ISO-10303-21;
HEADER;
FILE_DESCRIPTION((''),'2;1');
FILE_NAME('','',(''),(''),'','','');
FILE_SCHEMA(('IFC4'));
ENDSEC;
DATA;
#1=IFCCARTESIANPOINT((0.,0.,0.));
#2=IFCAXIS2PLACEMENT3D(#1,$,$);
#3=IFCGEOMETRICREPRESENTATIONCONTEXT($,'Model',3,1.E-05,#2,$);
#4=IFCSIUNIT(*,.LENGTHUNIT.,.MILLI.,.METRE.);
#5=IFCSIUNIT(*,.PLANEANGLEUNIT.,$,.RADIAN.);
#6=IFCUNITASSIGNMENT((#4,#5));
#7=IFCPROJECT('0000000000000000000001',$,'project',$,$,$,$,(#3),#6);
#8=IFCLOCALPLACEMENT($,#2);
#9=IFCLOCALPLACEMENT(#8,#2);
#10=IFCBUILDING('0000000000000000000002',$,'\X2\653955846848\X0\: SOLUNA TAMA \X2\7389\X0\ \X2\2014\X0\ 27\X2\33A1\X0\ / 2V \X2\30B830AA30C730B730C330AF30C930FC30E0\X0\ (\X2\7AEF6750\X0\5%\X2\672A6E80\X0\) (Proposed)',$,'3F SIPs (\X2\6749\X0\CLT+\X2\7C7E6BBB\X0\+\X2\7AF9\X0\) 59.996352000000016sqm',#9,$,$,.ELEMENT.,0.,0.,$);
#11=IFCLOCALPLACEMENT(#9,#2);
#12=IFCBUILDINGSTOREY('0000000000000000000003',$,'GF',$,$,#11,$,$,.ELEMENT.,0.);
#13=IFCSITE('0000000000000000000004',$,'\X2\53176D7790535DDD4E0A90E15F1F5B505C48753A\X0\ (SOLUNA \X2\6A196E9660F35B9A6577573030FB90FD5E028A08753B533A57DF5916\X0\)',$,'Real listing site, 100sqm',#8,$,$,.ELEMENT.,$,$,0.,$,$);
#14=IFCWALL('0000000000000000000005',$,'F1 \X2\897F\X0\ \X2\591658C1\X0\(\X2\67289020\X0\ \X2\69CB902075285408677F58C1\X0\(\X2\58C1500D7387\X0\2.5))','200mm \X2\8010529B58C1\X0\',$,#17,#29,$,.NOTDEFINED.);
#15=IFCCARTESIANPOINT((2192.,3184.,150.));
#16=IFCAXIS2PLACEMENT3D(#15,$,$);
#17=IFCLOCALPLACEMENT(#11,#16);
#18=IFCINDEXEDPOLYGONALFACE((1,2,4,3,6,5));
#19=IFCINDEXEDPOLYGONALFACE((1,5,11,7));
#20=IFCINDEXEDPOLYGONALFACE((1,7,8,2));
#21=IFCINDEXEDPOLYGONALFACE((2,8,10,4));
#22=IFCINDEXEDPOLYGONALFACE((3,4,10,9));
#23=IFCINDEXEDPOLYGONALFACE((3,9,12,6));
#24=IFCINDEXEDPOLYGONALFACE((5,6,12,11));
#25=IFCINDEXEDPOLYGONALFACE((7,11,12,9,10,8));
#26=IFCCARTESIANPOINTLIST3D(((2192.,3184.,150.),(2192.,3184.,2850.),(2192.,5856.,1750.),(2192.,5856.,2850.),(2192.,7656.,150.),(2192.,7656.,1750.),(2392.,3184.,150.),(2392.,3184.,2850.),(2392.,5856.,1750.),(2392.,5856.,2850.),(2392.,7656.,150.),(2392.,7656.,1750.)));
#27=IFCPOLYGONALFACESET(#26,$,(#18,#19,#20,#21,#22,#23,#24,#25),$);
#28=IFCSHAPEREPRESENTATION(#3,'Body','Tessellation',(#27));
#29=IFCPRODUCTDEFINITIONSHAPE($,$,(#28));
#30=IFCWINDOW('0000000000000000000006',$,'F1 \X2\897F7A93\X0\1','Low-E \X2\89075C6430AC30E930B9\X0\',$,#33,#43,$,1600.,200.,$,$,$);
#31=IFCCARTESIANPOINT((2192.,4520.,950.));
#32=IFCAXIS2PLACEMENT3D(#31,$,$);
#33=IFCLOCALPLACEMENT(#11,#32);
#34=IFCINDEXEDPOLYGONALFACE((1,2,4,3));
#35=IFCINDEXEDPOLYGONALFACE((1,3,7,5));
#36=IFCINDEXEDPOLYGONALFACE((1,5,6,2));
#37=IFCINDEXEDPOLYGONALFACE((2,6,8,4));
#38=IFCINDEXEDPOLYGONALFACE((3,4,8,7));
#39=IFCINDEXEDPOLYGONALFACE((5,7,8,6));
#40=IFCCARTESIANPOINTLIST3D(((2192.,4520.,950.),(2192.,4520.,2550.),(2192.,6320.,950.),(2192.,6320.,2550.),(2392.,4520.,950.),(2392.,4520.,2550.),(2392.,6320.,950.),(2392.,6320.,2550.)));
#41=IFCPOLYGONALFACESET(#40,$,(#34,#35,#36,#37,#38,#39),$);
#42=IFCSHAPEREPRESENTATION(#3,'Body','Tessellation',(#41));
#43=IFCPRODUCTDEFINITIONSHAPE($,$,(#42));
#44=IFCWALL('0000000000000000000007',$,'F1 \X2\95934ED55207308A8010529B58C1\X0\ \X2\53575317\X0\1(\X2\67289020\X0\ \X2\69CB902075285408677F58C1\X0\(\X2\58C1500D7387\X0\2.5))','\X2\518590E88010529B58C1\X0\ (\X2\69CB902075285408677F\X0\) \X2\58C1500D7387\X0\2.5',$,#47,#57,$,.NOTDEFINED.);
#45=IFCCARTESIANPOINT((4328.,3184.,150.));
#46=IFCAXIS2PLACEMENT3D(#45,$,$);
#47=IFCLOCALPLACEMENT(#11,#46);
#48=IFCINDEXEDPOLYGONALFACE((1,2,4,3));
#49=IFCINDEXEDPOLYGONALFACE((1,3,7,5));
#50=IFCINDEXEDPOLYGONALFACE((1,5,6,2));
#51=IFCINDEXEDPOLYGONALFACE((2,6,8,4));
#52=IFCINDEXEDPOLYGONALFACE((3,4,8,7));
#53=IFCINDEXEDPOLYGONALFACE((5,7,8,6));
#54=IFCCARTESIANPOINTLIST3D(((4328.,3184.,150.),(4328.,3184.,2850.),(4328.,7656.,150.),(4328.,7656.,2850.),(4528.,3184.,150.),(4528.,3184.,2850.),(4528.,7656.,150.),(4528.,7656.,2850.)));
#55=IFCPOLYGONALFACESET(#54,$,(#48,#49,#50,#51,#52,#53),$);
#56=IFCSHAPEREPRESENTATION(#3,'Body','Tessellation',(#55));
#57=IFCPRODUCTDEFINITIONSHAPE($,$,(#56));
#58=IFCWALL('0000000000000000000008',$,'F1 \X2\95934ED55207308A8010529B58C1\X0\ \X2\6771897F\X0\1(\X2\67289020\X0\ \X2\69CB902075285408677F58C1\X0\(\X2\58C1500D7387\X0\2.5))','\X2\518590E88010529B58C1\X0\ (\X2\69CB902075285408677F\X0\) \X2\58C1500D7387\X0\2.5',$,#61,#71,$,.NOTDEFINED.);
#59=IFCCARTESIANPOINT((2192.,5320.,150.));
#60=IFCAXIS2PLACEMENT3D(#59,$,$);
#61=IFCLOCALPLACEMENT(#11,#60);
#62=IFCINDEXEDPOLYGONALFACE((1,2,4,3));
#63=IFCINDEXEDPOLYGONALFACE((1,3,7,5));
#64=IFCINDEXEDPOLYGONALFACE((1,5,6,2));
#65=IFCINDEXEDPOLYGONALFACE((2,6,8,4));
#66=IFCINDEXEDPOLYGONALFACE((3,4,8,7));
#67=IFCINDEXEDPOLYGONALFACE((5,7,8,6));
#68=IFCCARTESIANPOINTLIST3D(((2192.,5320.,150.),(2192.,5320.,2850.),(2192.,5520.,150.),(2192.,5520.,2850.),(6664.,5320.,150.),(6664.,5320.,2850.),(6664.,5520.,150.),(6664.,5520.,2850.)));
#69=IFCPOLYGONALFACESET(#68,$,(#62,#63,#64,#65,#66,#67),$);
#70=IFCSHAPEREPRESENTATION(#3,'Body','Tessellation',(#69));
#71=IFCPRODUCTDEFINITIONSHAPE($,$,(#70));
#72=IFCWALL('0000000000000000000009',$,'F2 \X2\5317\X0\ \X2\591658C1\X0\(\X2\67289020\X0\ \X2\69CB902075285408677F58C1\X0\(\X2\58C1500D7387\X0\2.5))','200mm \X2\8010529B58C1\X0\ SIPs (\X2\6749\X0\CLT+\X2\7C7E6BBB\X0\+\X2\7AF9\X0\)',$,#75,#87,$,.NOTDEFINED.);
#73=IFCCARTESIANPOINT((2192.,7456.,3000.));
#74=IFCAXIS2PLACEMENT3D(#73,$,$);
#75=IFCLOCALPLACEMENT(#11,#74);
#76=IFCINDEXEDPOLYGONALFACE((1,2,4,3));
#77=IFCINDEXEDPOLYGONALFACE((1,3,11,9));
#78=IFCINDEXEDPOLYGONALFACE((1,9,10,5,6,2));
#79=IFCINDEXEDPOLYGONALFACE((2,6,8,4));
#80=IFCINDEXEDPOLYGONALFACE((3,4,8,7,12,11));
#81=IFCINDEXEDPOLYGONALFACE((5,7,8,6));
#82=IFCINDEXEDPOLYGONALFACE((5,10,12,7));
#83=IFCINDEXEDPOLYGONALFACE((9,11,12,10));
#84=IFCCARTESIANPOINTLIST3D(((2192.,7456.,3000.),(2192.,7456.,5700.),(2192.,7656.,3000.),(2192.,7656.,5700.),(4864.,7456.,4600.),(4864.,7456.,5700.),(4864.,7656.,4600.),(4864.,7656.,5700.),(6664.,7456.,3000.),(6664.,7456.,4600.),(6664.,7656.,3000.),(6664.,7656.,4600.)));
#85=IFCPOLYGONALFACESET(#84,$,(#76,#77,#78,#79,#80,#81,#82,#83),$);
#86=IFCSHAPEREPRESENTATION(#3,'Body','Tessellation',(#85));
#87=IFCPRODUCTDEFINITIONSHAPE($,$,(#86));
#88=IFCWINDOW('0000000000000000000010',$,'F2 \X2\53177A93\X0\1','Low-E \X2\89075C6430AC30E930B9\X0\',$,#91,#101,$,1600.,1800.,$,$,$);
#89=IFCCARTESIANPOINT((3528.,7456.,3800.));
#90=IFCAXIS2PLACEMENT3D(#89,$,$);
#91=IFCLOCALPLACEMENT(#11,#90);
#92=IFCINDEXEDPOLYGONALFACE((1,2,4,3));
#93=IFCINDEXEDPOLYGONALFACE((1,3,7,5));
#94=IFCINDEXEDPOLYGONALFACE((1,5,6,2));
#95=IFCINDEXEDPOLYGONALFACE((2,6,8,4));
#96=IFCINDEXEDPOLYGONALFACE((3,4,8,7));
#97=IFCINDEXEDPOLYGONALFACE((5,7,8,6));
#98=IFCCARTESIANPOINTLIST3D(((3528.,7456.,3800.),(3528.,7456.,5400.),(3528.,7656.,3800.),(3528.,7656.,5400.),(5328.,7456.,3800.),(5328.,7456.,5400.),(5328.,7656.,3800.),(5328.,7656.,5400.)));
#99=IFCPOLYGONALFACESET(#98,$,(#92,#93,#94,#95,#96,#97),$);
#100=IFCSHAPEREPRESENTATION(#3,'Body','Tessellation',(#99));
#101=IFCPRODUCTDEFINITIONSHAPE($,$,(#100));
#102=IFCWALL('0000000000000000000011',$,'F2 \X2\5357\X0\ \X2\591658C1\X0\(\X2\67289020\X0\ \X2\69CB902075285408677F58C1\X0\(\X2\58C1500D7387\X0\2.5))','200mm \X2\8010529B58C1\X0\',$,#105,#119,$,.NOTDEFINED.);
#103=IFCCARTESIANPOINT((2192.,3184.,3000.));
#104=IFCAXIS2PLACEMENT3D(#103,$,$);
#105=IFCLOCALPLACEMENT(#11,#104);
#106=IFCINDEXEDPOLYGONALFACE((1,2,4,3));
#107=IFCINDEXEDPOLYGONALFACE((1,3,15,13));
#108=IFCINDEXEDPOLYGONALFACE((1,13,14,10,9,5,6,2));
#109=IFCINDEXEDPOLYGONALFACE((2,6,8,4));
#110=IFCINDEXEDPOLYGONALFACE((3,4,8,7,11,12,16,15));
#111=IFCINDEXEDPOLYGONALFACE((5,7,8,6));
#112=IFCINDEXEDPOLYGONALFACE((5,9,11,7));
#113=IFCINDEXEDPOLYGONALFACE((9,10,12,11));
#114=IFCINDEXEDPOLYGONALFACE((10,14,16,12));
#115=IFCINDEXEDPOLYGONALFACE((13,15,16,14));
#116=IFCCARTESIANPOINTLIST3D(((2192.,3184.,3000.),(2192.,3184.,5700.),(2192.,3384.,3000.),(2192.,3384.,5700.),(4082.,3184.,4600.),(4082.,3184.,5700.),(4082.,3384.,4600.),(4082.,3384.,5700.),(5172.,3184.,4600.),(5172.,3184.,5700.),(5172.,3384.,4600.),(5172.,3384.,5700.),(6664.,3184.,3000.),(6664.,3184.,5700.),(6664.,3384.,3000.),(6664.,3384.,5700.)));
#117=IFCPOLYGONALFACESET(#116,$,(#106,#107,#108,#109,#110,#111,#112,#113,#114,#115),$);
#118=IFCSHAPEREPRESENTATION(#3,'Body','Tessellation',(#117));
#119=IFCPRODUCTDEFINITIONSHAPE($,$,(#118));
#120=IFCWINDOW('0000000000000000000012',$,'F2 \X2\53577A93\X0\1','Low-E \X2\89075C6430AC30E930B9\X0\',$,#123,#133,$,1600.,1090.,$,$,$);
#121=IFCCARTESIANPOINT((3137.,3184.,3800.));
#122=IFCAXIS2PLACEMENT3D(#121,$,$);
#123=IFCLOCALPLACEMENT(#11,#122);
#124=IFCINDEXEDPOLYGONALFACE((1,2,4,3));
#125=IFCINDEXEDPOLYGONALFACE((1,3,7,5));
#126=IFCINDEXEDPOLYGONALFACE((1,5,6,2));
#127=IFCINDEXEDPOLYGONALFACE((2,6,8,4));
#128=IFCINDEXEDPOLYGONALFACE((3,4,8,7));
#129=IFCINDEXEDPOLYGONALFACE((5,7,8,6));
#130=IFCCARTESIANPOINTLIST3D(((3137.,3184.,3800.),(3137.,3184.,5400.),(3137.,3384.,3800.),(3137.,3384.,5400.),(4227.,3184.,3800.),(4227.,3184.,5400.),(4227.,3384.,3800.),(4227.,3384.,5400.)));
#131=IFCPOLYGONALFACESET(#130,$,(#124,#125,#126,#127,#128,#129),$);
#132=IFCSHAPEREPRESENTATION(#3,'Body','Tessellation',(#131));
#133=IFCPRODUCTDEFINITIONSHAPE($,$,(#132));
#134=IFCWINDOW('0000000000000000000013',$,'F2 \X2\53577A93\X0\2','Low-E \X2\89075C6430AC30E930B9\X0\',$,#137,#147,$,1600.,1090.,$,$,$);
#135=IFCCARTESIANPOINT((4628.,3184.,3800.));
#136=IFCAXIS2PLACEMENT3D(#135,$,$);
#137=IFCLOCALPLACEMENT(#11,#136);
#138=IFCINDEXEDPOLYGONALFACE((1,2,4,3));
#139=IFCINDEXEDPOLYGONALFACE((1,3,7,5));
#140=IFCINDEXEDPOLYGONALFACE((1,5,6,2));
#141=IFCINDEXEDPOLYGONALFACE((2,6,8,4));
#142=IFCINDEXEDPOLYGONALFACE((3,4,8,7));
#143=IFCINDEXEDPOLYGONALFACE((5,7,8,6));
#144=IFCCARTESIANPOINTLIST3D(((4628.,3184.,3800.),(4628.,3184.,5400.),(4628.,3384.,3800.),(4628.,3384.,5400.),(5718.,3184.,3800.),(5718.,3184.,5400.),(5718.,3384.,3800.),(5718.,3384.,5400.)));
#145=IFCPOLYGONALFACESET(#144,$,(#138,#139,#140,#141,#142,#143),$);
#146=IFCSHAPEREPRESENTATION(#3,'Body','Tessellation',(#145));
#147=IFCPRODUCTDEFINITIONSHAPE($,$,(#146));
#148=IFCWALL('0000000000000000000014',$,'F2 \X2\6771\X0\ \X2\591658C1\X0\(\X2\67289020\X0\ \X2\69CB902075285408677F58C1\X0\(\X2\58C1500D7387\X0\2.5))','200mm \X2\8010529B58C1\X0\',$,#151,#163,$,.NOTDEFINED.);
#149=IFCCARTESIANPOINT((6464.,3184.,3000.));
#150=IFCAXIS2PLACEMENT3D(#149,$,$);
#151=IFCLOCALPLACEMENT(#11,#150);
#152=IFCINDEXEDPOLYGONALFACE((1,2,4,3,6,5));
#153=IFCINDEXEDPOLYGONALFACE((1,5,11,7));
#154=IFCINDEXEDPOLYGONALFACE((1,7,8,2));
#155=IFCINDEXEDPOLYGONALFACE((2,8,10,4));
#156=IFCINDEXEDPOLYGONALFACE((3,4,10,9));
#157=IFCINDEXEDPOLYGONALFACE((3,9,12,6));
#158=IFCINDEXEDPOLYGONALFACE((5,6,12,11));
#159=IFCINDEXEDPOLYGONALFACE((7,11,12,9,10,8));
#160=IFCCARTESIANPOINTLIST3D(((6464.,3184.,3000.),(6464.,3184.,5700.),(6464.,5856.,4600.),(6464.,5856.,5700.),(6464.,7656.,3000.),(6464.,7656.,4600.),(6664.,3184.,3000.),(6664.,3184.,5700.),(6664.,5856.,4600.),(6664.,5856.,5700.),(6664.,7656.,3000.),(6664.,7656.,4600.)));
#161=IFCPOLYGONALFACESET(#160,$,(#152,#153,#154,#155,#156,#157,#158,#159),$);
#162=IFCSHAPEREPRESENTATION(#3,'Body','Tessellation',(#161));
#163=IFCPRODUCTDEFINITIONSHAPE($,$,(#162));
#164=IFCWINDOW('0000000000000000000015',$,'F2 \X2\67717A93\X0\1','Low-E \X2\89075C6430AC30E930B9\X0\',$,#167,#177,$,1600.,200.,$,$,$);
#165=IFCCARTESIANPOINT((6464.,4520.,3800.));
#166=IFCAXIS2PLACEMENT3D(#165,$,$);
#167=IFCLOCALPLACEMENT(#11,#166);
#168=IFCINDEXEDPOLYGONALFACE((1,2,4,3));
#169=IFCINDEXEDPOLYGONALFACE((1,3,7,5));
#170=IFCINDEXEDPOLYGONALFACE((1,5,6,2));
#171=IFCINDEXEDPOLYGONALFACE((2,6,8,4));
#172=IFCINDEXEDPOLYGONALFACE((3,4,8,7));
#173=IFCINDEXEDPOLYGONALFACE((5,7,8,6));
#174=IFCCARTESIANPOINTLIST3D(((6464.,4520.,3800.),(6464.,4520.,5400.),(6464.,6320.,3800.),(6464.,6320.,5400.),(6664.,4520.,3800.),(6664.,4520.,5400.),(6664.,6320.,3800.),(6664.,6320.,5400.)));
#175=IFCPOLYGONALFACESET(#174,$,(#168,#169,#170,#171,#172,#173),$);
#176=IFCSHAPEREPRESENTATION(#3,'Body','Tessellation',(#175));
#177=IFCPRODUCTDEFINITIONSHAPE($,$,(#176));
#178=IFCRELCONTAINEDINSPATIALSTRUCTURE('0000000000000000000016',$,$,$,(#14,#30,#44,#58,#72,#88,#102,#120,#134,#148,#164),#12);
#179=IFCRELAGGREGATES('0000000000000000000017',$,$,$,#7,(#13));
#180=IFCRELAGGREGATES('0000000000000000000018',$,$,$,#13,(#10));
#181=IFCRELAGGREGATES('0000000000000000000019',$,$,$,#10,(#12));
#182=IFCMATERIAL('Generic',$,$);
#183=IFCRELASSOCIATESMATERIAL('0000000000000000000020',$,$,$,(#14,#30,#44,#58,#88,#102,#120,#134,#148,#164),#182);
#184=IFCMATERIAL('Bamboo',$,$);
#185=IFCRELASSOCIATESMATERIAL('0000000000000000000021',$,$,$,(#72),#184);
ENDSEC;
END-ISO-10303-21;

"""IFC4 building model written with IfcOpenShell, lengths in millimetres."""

from ifc_helpers import new_model, si_unit, frame, frame_2d, origin, place, context, project, spatial, rectangle, extrude, material, element, fill, save


model = new_model("IFC4")

# Units and contexts
model_context = context("Model", 3, precision=1e-05, world=origin())
ifc_project = project(units=[si_unit("LENGTHUNIT", "METRE", prefix="MILLI"), si_unit("PLANEANGLEUNIT", "RADIAN")], contexts=[model_context])

# Site, building, storey
site_placement = place(None, origin())
site = spatial("IfcSite", under=ifc_project, at=site_placement, Name="北海道川上郡弟子屈町 (SOLUNA 標準想定敷地・都市計画区域外)", ObjectType="Real listing site, 100sqm", CompositionType="ELEMENT", RefElevation=0.0)
building_placement = place(site_placement, origin())
building = spatial("IfcBuilding", under=site, at=building_placement, Name="改善案: SOLUNA TAMA 玉 — 27㎡ / 2V ジオデシックドーム (端材5%未満) (Proposed)", ObjectType="3F SIPs (杉CLT+籾殻+竹) 59.996352000000016sqm", CompositionType="ELEMENT", ElevationOfRefHeight=0.0, ElevationOfTerrain=0.0)
storey_placement = place(building_placement, origin())
storey = spatial("IfcBuildingStorey", under=building, at=storey_placement, Name="GF", CompositionType="ELEMENT", Elevation=0.0)

# Shared definitions
ifc_material_1 = material(Name="Generic")

# Shared definitions
ifc_material_2 = material(Name="Bamboo")

# Wall, opening, window
wall_1_placement = place(storey_placement, frame((2192.0, 3184.0, 150.0)))
wall_1 = element("IfcWall", 1, at=wall_1_placement, inside=storey, material=ifc_material_1, Name="F1 西 外壁(木造 構造用合板壁(壁倍率2.5))", Description="200mm 耐力壁", PredefinedType="NOTDEFINED", context=model_context, shape_type="SweptSolid", body=[
    extrude(rectangle(XDim=200.0, YDim=4472.0, at=frame_2d((100.0, 2236.0))), frame((2192.0, 3184.0, 150.0)), (0.0, 0.0, 1.0), 2700.0),
])
opening_1_placement = place(storey_placement, frame((2192.0, 4520.0, 950.0)))
opening_1 = element("IfcOpeningElement", 2, at=opening_1_placement, cuts=wall_1, PredefinedType="NOTDEFINED", context=model_context, shape_type="SweptSolid", body=[
    extrude(rectangle(XDim=200.0, YDim=1800.0, at=frame_2d((100.0, 900.0))), frame((2192.0, 4520.0, 950.0)), (0.0, 0.0, 1.0), 1600.0),
])
window_1_placement = place(storey_placement, frame((2192.0, 4520.0, 950.0)))
window_1 = element("IfcWindow", 3, at=window_1_placement, inside=storey, material=ifc_material_1, Name="F1 西窓1", Description="Low-E 複層ガラス", OverallHeight=1600.0, OverallWidth=200.0, context=model_context, shape_type="SweptSolid", body=[
    extrude(rectangle(XDim=200.0, YDim=1800.0, at=frame_2d((100.0, 900.0))), frame((2192.0, 4520.0, 950.0)), (0.0, 0.0, 1.0), 1600.0),
])
fill(opening_1, window_1)

# Walls
wall_2_placement = place(storey_placement, frame((4328.0, 3184.0, 150.0)))
element("IfcWall", 4, at=wall_2_placement, inside=storey, material=ifc_material_1, Name="F1 間仕切り耐力壁 南北1(木造 構造用合板壁(壁倍率2.5))", Description="内部耐力壁 (構造用合板) 壁倍率2.5", PredefinedType="NOTDEFINED", context=model_context, shape_type="SweptSolid", body=[
    extrude(rectangle(XDim=200.0, YDim=4472.0, at=frame_2d((100.0, 2236.0))), frame((4328.0, 3184.0, 150.0)), (0.0, 0.0, 1.0), 2700.0),
])
wall_3_placement = place(storey_placement, frame((2192.0, 5320.0, 150.0)))
element("IfcWall", 5, at=wall_3_placement, inside=storey, material=ifc_material_1, Name="F1 間仕切り耐力壁 東西1(木造 構造用合板壁(壁倍率2.5))", Description="内部耐力壁 (構造用合板) 壁倍率2.5", PredefinedType="NOTDEFINED", context=model_context, shape_type="SweptSolid", body=[
    extrude(rectangle(XDim=4472.0, YDim=200.0, at=frame_2d((2236.0, 100.0))), frame((2192.0, 5320.0, 150.0)), (0.0, 0.0, 1.0), 2700.0),
])

# Wall, opening, window
wall_4_placement = place(storey_placement, frame((2192.0, 7456.0, 3000.0)))
wall_4 = element("IfcWall", 6, at=wall_4_placement, inside=storey, material=ifc_material_2, Name="F2 北 外壁(木造 構造用合板壁(壁倍率2.5))", Description="200mm 耐力壁 SIPs (杉CLT+籾殻+竹)", PredefinedType="NOTDEFINED", context=model_context, shape_type="SweptSolid", body=[
    extrude(rectangle(XDim=4472.0, YDim=200.0, at=frame_2d((2236.0, 100.0))), frame((2192.0, 7456.0, 3000.0)), (0.0, 0.0, 1.0), 2700.0),
])
opening_2_placement = place(storey_placement, frame((3528.0, 7456.0, 3800.0)))
opening_2 = element("IfcOpeningElement", 7, at=opening_2_placement, cuts=wall_4, PredefinedType="NOTDEFINED", context=model_context, shape_type="SweptSolid", body=[
    extrude(rectangle(XDim=1800.0, YDim=200.0, at=frame_2d((900.0, 100.0))), frame((3528.0, 7456.0, 3800.0)), (0.0, 0.0, 1.0), 1600.0),
])
window_2_placement = place(storey_placement, frame((3528.0, 7456.0, 3800.0)))
window_2 = element("IfcWindow", 8, at=window_2_placement, inside=storey, material=ifc_material_1, Name="F2 北窓1", Description="Low-E 複層ガラス", OverallHeight=1600.0, OverallWidth=1800.0, context=model_context, shape_type="SweptSolid", body=[
    extrude(rectangle(XDim=1800.0, YDim=200.0, at=frame_2d((900.0, 100.0))), frame((3528.0, 7456.0, 3800.0)), (0.0, 0.0, 1.0), 1600.0),
])
fill(opening_2, window_2)

# Wall, openings, windows
wall_5_placement = place(storey_placement, frame((2192.0, 3184.0, 3000.0)))
wall_5 = element("IfcWall", 9, at=wall_5_placement, inside=storey, material=ifc_material_1, Name="F2 南 外壁(木造 構造用合板壁(壁倍率2.5))", Description="200mm 耐力壁", PredefinedType="NOTDEFINED", context=model_context, shape_type="SweptSolid", body=[
    extrude(rectangle(XDim=4472.0, YDim=200.0, at=frame_2d((2236.0, 100.0))), frame((2192.0, 3184.0, 3000.0)), (0.0, 0.0, 1.0), 2700.0),
])
opening_3_placement = place(storey_placement, frame((3137.0, 3184.0, 3800.0)))
opening_3 = element("IfcOpeningElement", 10, at=opening_3_placement, cuts=wall_5, PredefinedType="NOTDEFINED", context=model_context, shape_type="SweptSolid", body=[
    extrude(rectangle(XDim=1090.0, YDim=200.0, at=frame_2d((545.0, 100.0))), frame((3137.0, 3184.0, 3800.0)), (0.0, 0.0, 1.0), 1600.0),
])
opening_4_placement = place(storey_placement, frame((4628.0, 3184.0, 3800.0)))
opening_4 = element("IfcOpeningElement", 11, at=opening_4_placement, cuts=wall_5, PredefinedType="NOTDEFINED", context=model_context, shape_type="SweptSolid", body=[
    extrude(rectangle(XDim=1090.0, YDim=200.0, at=frame_2d((545.0, 100.0))), frame((4628.0, 3184.0, 3800.0)), (0.0, 0.0, 1.0), 1600.0),
])
window_3_placement = place(storey_placement, frame((3137.0, 3184.0, 3800.0)))
window_3 = element("IfcWindow", 12, at=window_3_placement, inside=storey, material=ifc_material_1, Name="F2 南窓1", Description="Low-E 複層ガラス", OverallHeight=1600.0, OverallWidth=1090.0, context=model_context, shape_type="SweptSolid", body=[
    extrude(rectangle(XDim=1090.0, YDim=200.0, at=frame_2d((545.0, 100.0))), frame((3137.0, 3184.0, 3800.0)), (0.0, 0.0, 1.0), 1600.0),
])
fill(opening_3, window_3)
window_4_placement = place(storey_placement, frame((4628.0, 3184.0, 3800.0)))
window_4 = element("IfcWindow", 13, at=window_4_placement, inside=storey, material=ifc_material_1, Name="F2 南窓2", Description="Low-E 複層ガラス", OverallHeight=1600.0, OverallWidth=1090.0, context=model_context, shape_type="SweptSolid", body=[
    extrude(rectangle(XDim=1090.0, YDim=200.0, at=frame_2d((545.0, 100.0))), frame((4628.0, 3184.0, 3800.0)), (0.0, 0.0, 1.0), 1600.0),
])
fill(opening_4, window_4)

# Wall, opening, window
wall_6_placement = place(storey_placement, frame((6464.0, 3184.0, 3000.0)))
wall_6 = element("IfcWall", 14, at=wall_6_placement, inside=storey, material=ifc_material_1, Name="F2 東 外壁(木造 構造用合板壁(壁倍率2.5))", Description="200mm 耐力壁", PredefinedType="NOTDEFINED", context=model_context, shape_type="SweptSolid", body=[
    extrude(rectangle(XDim=200.0, YDim=4472.0, at=frame_2d((100.0, 2236.0))), frame((6464.0, 3184.0, 3000.0)), (0.0, 0.0, 1.0), 2700.0),
])
opening_5_placement = place(storey_placement, frame((6464.0, 4520.0, 3800.0)))
opening_5 = element("IfcOpeningElement", 15, at=opening_5_placement, cuts=wall_6, PredefinedType="NOTDEFINED", context=model_context, shape_type="SweptSolid", body=[
    extrude(rectangle(XDim=200.0, YDim=1800.0, at=frame_2d((100.0, 900.0))), frame((6464.0, 4520.0, 3800.0)), (0.0, 0.0, 1.0), 1600.0),
])
window_5_placement = place(storey_placement, frame((6464.0, 4520.0, 3800.0)))
window_5 = element("IfcWindow", 16, at=window_5_placement, inside=storey, material=ifc_material_1, Name="F2 東窓1", Description="Low-E 複層ガラス", OverallHeight=1600.0, OverallWidth=200.0, context=model_context, shape_type="SweptSolid", body=[
    extrude(rectangle(XDim=200.0, YDim=1800.0, at=frame_2d((100.0, 900.0))), frame((6464.0, 4520.0, 3800.0)), (0.0, 0.0, 1.0), 1600.0),
])
fill(opening_5, window_5)

save(model, "model.ifc")
